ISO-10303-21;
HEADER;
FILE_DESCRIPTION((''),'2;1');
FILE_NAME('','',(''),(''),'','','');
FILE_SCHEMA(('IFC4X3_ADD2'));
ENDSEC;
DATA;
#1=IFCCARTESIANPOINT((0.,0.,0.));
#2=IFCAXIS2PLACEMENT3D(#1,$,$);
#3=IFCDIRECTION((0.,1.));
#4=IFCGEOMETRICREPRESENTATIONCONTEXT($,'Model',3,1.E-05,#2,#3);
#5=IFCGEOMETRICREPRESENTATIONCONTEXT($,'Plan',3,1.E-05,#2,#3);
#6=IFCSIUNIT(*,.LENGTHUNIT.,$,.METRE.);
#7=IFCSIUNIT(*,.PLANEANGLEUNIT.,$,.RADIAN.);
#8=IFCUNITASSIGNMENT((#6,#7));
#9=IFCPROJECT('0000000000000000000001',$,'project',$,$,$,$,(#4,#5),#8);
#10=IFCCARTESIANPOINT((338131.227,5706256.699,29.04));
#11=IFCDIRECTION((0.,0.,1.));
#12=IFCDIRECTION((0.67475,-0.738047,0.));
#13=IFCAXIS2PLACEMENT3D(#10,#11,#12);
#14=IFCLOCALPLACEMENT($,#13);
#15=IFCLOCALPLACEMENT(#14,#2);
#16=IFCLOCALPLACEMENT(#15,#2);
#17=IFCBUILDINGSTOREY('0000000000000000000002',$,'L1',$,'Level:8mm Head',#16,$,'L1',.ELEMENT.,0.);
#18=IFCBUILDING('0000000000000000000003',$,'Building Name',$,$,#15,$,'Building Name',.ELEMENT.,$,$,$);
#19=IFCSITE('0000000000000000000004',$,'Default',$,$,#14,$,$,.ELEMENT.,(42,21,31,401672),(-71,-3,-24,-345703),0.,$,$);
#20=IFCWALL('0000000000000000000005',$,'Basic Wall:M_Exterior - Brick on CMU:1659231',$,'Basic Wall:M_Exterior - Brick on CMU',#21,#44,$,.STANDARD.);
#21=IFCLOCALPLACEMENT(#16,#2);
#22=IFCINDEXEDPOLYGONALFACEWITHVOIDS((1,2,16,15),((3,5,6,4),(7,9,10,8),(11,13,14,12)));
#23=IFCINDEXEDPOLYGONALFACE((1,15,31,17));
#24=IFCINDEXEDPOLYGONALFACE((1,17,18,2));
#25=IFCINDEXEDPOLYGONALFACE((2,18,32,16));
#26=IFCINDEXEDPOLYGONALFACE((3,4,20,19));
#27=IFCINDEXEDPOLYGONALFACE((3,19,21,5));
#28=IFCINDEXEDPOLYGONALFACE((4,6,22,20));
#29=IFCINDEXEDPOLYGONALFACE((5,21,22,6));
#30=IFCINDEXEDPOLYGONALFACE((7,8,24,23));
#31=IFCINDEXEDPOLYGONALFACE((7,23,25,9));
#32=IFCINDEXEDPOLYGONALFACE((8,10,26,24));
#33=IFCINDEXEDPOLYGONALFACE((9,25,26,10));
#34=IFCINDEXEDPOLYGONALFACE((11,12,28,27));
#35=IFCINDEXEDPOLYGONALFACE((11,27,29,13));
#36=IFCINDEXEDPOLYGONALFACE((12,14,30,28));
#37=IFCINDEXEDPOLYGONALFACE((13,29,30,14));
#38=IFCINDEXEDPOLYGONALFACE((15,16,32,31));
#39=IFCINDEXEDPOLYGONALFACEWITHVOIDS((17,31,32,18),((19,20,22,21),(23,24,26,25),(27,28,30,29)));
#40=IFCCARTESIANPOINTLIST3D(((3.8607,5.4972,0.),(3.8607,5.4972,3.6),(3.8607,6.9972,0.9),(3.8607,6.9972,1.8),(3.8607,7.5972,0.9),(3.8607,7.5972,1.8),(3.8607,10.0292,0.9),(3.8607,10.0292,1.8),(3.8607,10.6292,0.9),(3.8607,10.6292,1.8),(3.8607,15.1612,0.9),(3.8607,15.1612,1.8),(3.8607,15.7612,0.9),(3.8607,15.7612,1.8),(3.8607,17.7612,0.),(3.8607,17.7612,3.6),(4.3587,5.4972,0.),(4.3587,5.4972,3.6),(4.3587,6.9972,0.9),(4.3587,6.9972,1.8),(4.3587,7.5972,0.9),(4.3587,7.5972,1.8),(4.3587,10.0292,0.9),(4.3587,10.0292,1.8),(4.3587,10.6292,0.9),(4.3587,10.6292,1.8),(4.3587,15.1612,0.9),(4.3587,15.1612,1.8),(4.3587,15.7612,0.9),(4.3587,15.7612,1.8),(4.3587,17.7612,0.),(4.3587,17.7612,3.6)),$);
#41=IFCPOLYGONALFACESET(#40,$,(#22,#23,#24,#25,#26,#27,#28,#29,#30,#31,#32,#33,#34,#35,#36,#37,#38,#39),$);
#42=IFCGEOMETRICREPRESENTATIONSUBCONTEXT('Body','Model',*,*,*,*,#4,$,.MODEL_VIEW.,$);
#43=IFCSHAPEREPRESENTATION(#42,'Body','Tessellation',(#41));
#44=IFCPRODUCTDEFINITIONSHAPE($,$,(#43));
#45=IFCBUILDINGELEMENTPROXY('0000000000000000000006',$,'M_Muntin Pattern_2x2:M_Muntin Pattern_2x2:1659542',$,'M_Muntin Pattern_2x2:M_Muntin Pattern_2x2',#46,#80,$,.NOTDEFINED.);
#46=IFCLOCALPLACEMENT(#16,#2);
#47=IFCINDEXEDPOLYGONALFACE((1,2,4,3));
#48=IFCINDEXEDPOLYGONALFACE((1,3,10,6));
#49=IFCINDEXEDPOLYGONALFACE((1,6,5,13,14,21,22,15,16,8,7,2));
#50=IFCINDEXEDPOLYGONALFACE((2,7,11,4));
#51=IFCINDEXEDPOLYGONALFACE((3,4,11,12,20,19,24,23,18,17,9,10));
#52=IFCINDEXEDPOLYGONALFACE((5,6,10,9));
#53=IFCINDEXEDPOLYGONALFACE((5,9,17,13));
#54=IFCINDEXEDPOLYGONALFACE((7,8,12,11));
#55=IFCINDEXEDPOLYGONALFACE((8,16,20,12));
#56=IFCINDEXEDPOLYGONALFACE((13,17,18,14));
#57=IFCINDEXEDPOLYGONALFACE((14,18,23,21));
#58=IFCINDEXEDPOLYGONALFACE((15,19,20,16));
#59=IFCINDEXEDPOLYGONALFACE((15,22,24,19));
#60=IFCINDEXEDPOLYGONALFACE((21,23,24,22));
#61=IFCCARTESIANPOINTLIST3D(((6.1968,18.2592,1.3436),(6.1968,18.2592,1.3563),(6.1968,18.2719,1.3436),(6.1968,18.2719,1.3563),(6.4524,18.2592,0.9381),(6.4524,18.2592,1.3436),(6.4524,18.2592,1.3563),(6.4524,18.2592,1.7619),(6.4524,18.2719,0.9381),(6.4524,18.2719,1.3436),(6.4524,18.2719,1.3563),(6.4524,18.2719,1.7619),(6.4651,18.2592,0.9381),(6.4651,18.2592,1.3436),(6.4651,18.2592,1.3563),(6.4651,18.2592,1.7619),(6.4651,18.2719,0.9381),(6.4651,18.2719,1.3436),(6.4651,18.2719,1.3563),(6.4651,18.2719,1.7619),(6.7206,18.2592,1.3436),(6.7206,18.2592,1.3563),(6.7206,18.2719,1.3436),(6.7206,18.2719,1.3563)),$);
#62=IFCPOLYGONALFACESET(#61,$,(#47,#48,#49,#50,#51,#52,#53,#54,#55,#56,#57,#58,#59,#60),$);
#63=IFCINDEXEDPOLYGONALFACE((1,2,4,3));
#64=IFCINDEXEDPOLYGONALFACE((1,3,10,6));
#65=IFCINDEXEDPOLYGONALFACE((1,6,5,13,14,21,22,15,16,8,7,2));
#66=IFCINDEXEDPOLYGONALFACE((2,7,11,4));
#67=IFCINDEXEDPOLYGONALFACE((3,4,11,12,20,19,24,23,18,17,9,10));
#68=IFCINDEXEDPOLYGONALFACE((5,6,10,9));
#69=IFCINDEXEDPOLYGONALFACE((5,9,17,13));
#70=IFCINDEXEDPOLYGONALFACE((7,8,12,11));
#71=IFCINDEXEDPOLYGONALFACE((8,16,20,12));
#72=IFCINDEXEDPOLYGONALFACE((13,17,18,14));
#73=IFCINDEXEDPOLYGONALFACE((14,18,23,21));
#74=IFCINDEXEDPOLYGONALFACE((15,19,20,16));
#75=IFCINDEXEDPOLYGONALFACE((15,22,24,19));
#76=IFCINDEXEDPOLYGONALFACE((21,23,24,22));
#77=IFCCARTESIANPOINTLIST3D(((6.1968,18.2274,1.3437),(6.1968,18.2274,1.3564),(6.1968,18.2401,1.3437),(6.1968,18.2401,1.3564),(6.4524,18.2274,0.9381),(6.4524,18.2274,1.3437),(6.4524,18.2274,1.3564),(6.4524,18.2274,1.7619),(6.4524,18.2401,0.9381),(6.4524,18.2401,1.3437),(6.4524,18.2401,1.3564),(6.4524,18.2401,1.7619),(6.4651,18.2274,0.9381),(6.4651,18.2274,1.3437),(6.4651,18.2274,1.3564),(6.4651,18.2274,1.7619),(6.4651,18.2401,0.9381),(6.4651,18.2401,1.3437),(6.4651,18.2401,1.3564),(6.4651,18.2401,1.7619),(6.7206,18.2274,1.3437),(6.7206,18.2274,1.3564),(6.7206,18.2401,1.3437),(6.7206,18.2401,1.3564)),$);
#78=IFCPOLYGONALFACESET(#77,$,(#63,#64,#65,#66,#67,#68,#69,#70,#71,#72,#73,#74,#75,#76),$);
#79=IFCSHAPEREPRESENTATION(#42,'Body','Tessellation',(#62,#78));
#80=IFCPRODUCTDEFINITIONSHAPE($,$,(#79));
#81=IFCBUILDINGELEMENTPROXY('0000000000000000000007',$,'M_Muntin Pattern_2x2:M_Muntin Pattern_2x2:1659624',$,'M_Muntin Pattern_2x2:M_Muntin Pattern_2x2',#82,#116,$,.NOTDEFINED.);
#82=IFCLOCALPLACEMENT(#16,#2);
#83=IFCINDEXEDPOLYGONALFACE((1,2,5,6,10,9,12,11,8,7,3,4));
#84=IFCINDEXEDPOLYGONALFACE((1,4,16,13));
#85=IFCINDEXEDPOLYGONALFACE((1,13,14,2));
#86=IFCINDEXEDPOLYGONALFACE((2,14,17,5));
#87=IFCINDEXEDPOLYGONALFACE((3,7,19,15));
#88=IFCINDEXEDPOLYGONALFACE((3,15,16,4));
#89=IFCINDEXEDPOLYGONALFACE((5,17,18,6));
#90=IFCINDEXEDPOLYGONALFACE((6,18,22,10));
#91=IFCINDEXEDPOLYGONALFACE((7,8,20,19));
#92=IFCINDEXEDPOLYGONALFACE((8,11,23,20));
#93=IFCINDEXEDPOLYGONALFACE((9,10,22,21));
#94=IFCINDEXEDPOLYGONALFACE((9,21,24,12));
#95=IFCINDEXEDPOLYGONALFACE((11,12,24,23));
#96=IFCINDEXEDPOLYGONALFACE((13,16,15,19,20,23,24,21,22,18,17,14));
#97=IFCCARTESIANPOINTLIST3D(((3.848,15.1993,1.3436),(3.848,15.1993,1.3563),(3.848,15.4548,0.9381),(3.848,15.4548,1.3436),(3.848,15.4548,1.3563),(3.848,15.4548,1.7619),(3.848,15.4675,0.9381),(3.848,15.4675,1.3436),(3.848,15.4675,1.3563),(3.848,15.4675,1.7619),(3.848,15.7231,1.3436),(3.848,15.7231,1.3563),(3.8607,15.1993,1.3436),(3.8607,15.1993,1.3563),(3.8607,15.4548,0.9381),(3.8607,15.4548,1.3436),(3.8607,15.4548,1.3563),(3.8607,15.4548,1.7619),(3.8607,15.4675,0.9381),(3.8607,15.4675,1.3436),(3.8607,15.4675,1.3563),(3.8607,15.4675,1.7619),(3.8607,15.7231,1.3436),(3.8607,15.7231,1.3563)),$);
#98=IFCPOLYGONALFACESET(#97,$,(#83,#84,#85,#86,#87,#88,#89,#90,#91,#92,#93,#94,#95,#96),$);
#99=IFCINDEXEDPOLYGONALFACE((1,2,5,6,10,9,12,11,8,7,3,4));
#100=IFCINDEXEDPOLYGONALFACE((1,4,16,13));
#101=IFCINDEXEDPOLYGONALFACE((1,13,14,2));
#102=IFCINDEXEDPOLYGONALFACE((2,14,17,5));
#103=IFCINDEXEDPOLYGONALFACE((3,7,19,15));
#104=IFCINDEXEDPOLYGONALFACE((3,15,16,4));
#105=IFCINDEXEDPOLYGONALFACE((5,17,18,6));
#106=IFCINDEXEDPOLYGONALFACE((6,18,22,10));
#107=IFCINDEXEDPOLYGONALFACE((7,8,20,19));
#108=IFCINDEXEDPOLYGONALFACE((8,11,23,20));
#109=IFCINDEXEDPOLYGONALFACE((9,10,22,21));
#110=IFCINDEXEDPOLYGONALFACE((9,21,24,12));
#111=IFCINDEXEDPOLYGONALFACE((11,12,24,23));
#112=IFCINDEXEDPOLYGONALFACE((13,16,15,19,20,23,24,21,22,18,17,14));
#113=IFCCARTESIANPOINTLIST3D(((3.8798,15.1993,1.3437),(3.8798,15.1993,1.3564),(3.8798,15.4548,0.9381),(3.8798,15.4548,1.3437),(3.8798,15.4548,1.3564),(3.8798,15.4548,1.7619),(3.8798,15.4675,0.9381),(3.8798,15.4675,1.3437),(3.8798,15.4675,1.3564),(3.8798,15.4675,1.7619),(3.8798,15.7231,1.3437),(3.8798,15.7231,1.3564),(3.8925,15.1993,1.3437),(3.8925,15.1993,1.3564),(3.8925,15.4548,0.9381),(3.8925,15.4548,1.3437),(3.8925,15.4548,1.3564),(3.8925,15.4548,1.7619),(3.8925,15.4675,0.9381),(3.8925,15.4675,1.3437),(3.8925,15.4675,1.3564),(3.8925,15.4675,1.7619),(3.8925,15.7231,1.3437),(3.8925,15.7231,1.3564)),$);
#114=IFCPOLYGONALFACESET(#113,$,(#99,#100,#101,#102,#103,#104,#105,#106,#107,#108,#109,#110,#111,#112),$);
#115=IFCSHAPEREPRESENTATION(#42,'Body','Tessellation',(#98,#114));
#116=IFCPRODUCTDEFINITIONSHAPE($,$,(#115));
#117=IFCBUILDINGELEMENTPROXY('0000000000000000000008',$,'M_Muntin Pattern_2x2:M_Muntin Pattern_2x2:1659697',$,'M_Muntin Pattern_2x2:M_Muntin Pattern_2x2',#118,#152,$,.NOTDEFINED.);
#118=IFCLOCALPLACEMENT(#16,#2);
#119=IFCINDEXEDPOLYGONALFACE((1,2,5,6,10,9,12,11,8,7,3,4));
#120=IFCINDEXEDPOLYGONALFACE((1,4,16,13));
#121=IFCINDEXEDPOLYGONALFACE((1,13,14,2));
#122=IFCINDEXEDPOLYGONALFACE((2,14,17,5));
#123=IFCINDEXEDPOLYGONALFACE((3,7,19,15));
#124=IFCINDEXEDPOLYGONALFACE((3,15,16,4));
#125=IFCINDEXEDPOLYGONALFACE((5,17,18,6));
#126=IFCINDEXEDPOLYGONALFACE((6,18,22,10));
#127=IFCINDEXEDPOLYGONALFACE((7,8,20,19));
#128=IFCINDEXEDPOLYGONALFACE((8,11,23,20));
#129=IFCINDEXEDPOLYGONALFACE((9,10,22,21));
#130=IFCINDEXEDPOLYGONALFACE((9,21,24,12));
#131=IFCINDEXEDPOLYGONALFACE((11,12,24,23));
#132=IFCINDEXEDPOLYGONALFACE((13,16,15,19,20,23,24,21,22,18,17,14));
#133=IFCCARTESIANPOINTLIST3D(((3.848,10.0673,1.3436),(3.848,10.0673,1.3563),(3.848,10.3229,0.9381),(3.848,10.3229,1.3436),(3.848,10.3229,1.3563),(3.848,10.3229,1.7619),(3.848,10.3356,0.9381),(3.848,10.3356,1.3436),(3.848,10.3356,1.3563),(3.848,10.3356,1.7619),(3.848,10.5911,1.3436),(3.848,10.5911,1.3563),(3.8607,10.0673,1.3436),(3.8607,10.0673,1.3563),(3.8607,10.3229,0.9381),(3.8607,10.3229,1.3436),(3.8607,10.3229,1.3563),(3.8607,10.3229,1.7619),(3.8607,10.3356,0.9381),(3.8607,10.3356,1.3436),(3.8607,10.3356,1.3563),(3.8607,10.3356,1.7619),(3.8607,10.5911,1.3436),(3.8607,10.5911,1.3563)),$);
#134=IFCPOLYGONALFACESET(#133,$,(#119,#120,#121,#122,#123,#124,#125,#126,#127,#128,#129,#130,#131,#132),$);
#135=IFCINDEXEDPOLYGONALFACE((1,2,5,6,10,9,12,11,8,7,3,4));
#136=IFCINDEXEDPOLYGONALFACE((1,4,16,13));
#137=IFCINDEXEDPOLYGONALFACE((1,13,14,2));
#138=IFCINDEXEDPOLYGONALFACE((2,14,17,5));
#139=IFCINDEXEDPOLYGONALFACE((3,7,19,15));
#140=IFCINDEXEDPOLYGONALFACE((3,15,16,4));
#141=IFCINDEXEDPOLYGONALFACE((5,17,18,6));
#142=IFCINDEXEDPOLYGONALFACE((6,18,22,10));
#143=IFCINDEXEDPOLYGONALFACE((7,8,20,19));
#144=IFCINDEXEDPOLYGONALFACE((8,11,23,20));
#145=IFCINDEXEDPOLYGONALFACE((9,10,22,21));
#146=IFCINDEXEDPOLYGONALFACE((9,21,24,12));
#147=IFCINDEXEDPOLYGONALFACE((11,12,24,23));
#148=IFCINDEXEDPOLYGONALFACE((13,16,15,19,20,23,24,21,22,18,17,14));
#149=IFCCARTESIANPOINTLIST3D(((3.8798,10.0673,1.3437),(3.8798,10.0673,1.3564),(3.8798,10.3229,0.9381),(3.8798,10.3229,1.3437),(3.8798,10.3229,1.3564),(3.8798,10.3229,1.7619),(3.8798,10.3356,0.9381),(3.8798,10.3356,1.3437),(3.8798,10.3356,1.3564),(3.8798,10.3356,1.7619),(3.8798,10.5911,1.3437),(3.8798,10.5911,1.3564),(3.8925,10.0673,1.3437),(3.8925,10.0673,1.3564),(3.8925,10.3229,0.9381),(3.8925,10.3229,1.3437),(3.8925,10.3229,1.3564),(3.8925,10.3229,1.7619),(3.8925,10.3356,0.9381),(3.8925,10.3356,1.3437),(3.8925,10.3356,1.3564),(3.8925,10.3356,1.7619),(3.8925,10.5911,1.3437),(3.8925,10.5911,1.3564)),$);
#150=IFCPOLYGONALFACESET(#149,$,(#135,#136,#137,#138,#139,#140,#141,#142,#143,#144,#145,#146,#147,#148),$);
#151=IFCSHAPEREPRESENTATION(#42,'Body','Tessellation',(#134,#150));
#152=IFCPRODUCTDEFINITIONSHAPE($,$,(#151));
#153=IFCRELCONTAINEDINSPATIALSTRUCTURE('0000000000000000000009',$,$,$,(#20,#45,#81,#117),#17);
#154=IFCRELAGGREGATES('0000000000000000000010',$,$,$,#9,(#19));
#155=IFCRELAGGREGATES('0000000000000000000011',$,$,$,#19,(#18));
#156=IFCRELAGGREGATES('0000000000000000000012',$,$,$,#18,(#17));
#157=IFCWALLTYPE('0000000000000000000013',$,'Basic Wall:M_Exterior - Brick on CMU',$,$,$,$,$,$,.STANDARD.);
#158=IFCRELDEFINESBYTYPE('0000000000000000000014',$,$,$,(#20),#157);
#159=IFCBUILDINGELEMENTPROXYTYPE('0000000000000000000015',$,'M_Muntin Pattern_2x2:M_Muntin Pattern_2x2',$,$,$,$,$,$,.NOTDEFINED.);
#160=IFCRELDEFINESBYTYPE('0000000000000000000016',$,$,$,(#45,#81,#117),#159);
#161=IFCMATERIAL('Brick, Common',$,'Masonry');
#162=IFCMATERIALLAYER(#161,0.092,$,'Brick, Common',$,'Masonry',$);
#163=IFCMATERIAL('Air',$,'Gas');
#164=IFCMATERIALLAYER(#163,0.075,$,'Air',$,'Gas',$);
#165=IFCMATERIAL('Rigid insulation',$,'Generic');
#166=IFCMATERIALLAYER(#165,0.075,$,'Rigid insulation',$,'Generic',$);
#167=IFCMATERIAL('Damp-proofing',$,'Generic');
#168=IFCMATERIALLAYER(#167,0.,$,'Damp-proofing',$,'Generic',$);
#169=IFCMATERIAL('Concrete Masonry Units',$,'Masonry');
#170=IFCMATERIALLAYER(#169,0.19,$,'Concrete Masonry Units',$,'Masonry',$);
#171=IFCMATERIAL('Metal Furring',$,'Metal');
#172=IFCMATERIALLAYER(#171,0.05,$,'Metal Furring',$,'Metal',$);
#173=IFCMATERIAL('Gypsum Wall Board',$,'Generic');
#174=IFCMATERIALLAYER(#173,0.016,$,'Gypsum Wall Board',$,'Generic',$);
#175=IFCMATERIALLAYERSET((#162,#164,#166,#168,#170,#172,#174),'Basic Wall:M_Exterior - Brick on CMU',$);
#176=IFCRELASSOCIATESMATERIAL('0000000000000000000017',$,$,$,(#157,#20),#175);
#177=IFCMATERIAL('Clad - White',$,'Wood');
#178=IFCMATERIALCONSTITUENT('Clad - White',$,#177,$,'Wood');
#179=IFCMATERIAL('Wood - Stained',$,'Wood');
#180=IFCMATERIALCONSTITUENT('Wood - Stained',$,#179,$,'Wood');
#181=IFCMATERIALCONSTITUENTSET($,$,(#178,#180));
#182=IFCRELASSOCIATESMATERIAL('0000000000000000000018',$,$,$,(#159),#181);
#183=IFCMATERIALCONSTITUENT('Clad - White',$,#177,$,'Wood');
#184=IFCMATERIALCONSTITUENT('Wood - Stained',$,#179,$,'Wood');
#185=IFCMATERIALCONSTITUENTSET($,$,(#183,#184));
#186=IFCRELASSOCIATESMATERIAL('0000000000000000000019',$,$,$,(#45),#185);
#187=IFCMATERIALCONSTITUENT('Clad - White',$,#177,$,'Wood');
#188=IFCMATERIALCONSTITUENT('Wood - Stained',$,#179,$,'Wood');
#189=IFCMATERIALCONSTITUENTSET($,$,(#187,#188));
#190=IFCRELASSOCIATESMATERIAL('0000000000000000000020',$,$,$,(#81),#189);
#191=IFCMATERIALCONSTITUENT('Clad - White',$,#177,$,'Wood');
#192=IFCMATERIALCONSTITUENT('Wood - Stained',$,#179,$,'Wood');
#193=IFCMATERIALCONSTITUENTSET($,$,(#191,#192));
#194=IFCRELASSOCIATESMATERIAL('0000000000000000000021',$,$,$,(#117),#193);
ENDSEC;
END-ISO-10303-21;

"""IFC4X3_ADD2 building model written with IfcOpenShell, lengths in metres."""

from ifc_helpers import new_model, si_unit, direction, frame, frame_2d, origin, origin_2d_with_axis, place, context, subcontext, project, spatial, polyline, rectangle, outline, extrude, source, transform, mapped, material, layer, layer_set, constituent, constituent_set, type_object, type_shapes, element, save


model = new_model("IFC4X3_ADD2")

# Units and contexts
model_context = context("Model", 3, precision=1e-05, world=origin(), true_north=direction((0.0, 1.0)))
plan_context = context("Plan", 3, precision=1e-05, world=origin(), true_north=direction((0.0, 1.0)))
body_context = subcontext(model_context, "Body", "Model", "MODEL_VIEW")
ifc_project = project(units=[si_unit("LENGTHUNIT", "METRE"), si_unit("PLANEANGLEUNIT", "RADIAN")], contexts=[model_context, plan_context])

# Site, building, storey
site_placement = place(None, frame((338131.227, 5706256.699, 29.04), z_axis=(0.0, 0.0, 1.0), x_axis=(0.67475, -0.738047, 0.0)))
site = spatial("IfcSite", under=ifc_project, at=site_placement, Name="Default", CompositionType="ELEMENT", RefLatitude=(42, 21, 31, 401672), RefLongitude=(-71, -3, -24, -345703), RefElevation=0.0)
building_placement = place(site_placement, origin())
building = spatial("IfcBuilding", under=site, at=building_placement, Name="Building Name", LongName="Building Name", CompositionType="ELEMENT")
storey_placement = place(building_placement, origin())
storey = spatial("IfcBuildingStorey", under=building, at=storey_placement, Name="L1", ObjectType="Level:8mm Head", LongName="L1", CompositionType="ELEMENT", Elevation=0.0)

# Shared definitions
ifc_material_1 = material(Name="Brick, Common", Category="Masonry")
ifc_layer_1 = layer(ifc_material_1, 0.092, Name="Brick, Common", Category="Masonry")
ifc_material_2 = material(Name="Air", Category="Gas")
ifc_layer_2 = layer(ifc_material_2, 0.075, Name="Air", Category="Gas")
ifc_material_3 = material(Name="Rigid insulation", Category="Generic")
ifc_layer_3 = layer(ifc_material_3, 0.075, Name="Rigid insulation", Category="Generic")
ifc_material_4 = material(Name="Damp-proofing", Category="Generic")
ifc_layer_4 = layer(ifc_material_4, 0.0, Name="Damp-proofing", Category="Generic")
ifc_material_5 = material(Name="Concrete Masonry Units", Category="Masonry")
ifc_layer_5 = layer(ifc_material_5, 0.19, Name="Concrete Masonry Units", Category="Masonry")
ifc_material_6 = material(Name="Metal Furring", Category="Metal")
ifc_layer_6 = layer(ifc_material_6, 0.05, Name="Metal Furring", Category="Metal")
ifc_material_7 = material(Name="Gypsum Wall Board", Category="Generic")
ifc_layer_7 = layer(ifc_material_7, 0.016, Name="Gypsum Wall Board", Category="Generic")
ifc_layer_set_1 = layer_set([ifc_layer_1, ifc_layer_2, ifc_layer_3, ifc_layer_4, ifc_layer_5, ifc_layer_6, ifc_layer_7], Name="Basic Wall:M_Exterior - Brick on CMU")
wall_type = type_object("IfcWallType", Name="Basic Wall:M_Exterior - Brick on CMU", PredefinedType="STANDARD", material=ifc_layer_set_1)

# Wall, openings
wall_1_placement = place(storey_placement, frame((4.1097, 5.4972, 0.0), z_axis=(0.0, 0.0, 1.0), x_axis=(0.0, 1.0, 0.0)))
wall_1 = element("IfcWall", 1, at=wall_1_placement, inside=storey, type_object=wall_type, material=ifc_layer_set_1, Name="Basic Wall:M_Exterior - Brick on CMU:1659231", ObjectType="Basic Wall:M_Exterior - Brick on CMU", PredefinedType="STANDARD", context=body_context, shape_type="SweptSolid", body=[
    extrude(rectangle(XDim=12.264, YDim=0.498, at=frame_2d((6.132, 0.0), x_axis=(-1.0, 0.0))), origin(), (0.0, 0.0, 1.0), 3.6),
])
opening_1_placement = place(wall_1_placement, frame((-5.4972, 4.1097, 0.9)))
element("IfcOpeningElement", 2, at=opening_1_placement, cuts=wall_1, PredefinedType="OPENING", context=body_context, shape_type="SweptSolid", body=[
    extrude(rectangle(XDim=0.9, YDim=0.6, at=frame_2d((0.0, 0.0), x_axis=(1.0, 0.0))), frame((15.4612, -5.8827, 0.45), z_axis=(0.0, 1.0, 0.0), x_axis=(0.0, 0.0, -1.0)), (0.0, 0.0, 1.0), 3.048),
])
opening_2_placement = place(wall_1_placement, frame((-5.4972, 4.1097, 0.9)))
element("IfcOpeningElement", 3, at=opening_2_placement, cuts=wall_1, PredefinedType="OPENING", context=body_context, shape_type="SweptSolid", body=[
    extrude(rectangle(XDim=0.9, YDim=0.6, at=frame_2d((0.0, 0.0), x_axis=(1.0, 0.0))), frame((10.3292, -5.8827, 0.45), z_axis=(0.0, 1.0, 0.0), x_axis=(0.0, 0.0, -1.0)), (0.0, 0.0, 1.0), 3.048),
])
opening_3_placement = place(wall_1_placement, frame((-5.4972, 4.1097, 0.9)))
element("IfcOpeningElement", 4, at=opening_3_placement, cuts=wall_1, PredefinedType="OPENING", context=body_context, shape_type="SweptSolid", body=[
    extrude(rectangle(XDim=0.9, YDim=0.6, at=origin_2d_with_axis()), frame((7.2972, -5.8827, 0.45), z_axis=(0.0, 1.0, 0.0), x_axis=(0.0, 0.0, -1.0)), (0.0, 0.0, 1.0), 3.048),
])

# Building element proxies
ifc_material_8 = material(Name="Clad - White", Category="Wood")
ifc_constituent_1 = constituent(ifc_material_8, Name="Clad - White", Category="Wood")
ifc_material_9 = material(Name="Wood - Stained", Category="Wood")
ifc_constituent_2 = constituent(ifc_material_9, Name="Wood - Stained", Category="Wood")
ifc_constituent_set_1 = constituent_set(constituents=[ifc_constituent_1, ifc_constituent_2])
ifc_constituent_3 = constituent(ifc_material_8, Name="Clad - White", Category="Wood")
ifc_constituent_4 = constituent(ifc_material_9, Name="Wood - Stained", Category="Wood")
ifc_constituent_set_2 = constituent_set(constituents=[ifc_constituent_3, ifc_constituent_4])
building_element_proxy_type = type_object("IfcBuildingElementProxyType", Name="M_Muntin Pattern_2x2:M_Muntin Pattern_2x2", PredefinedType="NOTDEFINED", material=ifc_constituent_set_2)
shared_shape = source(origin(), body_context, "Body", "SweptSolid", [
    extrude(outline(polyline([(0.0064, -0.0064), (0.4119, -0.0064), (0.4119, 0.0063), (0.0064, 0.0063), (0.0064, 0.2619), (-0.0063, 0.2619), (-0.0063, 0.0063), (-0.4119, 0.0063), (-0.4119, -0.0064), (-0.0063, -0.0064), (-0.0063, -0.2619), (0.0064, -0.2619), (0.0064, -0.0064)])), frame((0.0, -0.0222, 0.4119), z_axis=(0.0, 1.0, 0.0), x_axis=(0.0, 0.0, 1.0)), (0.0, 0.0, 1.0), 0.0127),
    extrude(outline(polyline([(0.0064, -0.0064), (0.4119, -0.0064), (0.4119, 0.0063), (0.0064, 0.0063), (0.0064, 0.2619), (-0.0063, 0.2619), (-0.0063, 0.0063), (-0.4119, 0.0063), (-0.4119, -0.0064), (-0.0063, -0.0064), (-0.0063, -0.2619), (0.0064, -0.2619), (0.0064, -0.0064)])), frame((0.0, 0.0095, 0.4119), z_axis=(0.0, 1.0, 0.0), x_axis=(0.0, 0.0, 1.0)), (0.0, 0.0, 1.0), 0.0127),
])
type_shapes(building_element_proxy_type, [shared_shape])
proxy_1_placement = place(storey_placement, frame((6.4587, 18.2497, 0.9381), z_axis=(0.0, 0.0, 1.0), x_axis=(-1.0, 0.0, 0.0)))
element("IfcBuildingElementProxy", 5, at=proxy_1_placement, inside=storey, type_object=building_element_proxy_type, material=ifc_constituent_set_1, Name="M_Muntin Pattern_2x2:M_Muntin Pattern_2x2:1659542", ObjectType="M_Muntin Pattern_2x2:M_Muntin Pattern_2x2", PredefinedType="NOTDEFINED", context=body_context, shape_type="MappedRepresentation", body=[
    mapped(shared_shape, transform((0.0, 0.0, 0.0), scale=1.0)),
])
ifc_constituent_5 = constituent(ifc_material_8, Name="Clad - White", Category="Wood")
ifc_constituent_6 = constituent(ifc_material_9, Name="Wood - Stained", Category="Wood")
ifc_constituent_set_3 = constituent_set(constituents=[ifc_constituent_5, ifc_constituent_6])
proxy_2_placement = place(storey_placement, frame((3.8703, 15.4612, 0.9381), z_axis=(0.0, 0.0, 1.0), x_axis=(0.0, -1.0, 0.0)))
element("IfcBuildingElementProxy", 6, at=proxy_2_placement, inside=storey, type_object=building_element_proxy_type, material=ifc_constituent_set_3, Name="M_Muntin Pattern_2x2:M_Muntin Pattern_2x2:1659624", ObjectType="M_Muntin Pattern_2x2:M_Muntin Pattern_2x2", PredefinedType="NOTDEFINED", context=body_context, shape_type="MappedRepresentation", body=[
    mapped(shared_shape, transform((0.0, 0.0, 0.0), scale=1.0)),
])
ifc_constituent_7 = constituent(ifc_material_8, Name="Clad - White", Category="Wood")
ifc_constituent_8 = constituent(ifc_material_9, Name="Wood - Stained", Category="Wood")
ifc_constituent_set_4 = constituent_set(constituents=[ifc_constituent_7, ifc_constituent_8])
proxy_3_placement = place(storey_placement, frame((3.8703, 10.3292, 0.9381), z_axis=(0.0, 0.0, 1.0), x_axis=(0.0, -1.0, 0.0)))
element("IfcBuildingElementProxy", 7, at=proxy_3_placement, inside=storey, type_object=building_element_proxy_type, material=ifc_constituent_set_4, Name="M_Muntin Pattern_2x2:M_Muntin Pattern_2x2:1659697", ObjectType="M_Muntin Pattern_2x2:M_Muntin Pattern_2x2", PredefinedType="NOTDEFINED", context=body_context, shape_type="MappedRepresentation", body=[
    mapped(shared_shape, transform((0.0, 0.0, 0.0), scale=1.0)),
])

save(model, "model.ifc")
